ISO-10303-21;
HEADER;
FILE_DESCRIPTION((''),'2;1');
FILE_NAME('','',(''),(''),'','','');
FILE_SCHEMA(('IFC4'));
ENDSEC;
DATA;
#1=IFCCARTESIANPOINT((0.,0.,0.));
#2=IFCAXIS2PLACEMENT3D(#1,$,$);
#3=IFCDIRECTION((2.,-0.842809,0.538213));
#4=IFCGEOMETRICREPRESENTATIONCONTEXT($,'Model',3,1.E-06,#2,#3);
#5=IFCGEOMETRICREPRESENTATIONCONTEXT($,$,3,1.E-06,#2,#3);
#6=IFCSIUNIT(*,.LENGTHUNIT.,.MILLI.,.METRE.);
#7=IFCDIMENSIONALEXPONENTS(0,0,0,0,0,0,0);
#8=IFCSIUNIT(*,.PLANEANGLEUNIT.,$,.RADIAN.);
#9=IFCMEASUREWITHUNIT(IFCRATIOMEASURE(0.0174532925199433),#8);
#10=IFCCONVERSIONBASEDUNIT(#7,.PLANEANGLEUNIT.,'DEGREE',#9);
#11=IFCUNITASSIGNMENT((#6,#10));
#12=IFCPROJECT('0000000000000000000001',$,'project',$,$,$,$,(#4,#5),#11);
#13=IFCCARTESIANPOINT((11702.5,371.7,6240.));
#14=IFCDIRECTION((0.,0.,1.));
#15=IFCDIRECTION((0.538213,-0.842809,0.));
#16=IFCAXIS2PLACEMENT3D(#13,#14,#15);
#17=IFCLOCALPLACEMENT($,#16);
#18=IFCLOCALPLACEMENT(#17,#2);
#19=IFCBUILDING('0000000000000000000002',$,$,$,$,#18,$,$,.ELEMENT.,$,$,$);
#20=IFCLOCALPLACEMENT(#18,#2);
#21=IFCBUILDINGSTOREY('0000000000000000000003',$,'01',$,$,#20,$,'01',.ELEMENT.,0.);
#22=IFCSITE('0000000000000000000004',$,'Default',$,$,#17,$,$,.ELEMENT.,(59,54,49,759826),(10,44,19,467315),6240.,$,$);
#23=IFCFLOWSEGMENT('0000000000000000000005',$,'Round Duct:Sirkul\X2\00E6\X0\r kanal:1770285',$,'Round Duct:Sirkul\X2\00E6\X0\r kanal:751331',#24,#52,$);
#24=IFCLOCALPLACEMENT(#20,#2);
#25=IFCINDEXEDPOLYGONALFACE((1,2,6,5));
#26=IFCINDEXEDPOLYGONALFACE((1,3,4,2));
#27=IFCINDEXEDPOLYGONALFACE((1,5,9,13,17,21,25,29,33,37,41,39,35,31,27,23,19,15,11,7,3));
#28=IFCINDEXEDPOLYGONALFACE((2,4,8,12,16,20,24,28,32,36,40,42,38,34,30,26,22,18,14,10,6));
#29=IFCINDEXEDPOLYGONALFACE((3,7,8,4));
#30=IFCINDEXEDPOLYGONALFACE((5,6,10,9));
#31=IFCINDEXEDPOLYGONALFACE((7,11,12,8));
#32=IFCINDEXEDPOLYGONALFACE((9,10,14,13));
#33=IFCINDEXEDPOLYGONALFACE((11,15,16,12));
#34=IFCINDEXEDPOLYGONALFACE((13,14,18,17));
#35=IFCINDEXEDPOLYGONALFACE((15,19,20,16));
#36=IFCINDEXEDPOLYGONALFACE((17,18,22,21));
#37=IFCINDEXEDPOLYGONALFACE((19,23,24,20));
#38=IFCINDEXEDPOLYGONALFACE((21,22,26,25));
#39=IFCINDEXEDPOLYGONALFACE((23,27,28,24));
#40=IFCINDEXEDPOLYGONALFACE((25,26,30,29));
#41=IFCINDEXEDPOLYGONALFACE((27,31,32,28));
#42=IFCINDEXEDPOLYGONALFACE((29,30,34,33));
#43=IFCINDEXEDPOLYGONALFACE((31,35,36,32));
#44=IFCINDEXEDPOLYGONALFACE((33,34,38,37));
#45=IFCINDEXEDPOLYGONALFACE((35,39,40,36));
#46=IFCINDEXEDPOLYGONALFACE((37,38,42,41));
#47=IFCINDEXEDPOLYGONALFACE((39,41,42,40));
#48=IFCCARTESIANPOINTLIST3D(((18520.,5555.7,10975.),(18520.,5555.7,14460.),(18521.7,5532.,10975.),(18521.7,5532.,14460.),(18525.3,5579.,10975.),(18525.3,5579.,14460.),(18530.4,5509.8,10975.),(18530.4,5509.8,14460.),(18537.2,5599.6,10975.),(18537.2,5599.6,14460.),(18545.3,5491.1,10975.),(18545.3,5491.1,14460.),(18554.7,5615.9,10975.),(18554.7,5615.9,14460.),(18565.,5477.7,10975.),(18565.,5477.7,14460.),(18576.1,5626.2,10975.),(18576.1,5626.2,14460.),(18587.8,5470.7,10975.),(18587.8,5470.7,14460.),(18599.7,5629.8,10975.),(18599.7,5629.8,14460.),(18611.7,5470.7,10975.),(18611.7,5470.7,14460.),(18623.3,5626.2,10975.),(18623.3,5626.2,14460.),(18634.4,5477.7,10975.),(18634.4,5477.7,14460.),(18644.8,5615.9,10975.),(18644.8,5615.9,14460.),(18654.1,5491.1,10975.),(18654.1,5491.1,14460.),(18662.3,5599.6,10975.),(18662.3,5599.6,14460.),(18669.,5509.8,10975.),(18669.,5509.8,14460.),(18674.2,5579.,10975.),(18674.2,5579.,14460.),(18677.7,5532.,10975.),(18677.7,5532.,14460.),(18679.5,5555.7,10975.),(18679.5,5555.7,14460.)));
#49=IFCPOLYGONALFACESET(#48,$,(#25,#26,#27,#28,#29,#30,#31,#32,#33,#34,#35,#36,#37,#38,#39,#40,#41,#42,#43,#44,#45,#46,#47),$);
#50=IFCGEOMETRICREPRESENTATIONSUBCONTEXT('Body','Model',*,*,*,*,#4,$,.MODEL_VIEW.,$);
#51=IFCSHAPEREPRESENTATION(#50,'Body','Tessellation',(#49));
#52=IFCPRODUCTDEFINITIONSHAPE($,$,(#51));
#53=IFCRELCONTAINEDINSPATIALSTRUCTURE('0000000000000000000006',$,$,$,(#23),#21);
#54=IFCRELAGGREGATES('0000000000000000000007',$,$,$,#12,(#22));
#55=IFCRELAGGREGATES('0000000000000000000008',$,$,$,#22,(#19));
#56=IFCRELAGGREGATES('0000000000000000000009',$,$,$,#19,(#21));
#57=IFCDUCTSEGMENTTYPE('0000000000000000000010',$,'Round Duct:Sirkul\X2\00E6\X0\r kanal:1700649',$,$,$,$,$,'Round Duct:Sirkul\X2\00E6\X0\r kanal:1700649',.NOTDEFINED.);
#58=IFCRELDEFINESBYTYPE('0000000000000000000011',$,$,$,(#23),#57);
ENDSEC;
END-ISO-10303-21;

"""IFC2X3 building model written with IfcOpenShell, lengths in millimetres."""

from ifc_helpers import new_model, entity, si_unit, converted_unit, direction, frame, origin, origin_2d_with_axis, place, context, subcontext, project, spatial, circle, extrude, type_object, element, save


model = new_model("IFC2X3")

# Units and contexts
model_context = context("Model", 3, precision=1e-06, world=origin(), true_north=direction((2.0, -0.842809, 0.538213)))
context_of_model = context(None, 3, precision=1e-06, world=origin(), true_north=direction((2.0, -0.842809, 0.538213)))
body_context = subcontext(model_context, "Body", "Model", "MODEL_VIEW")
ifc_project = project(units=[si_unit("LENGTHUNIT", "METRE", prefix="MILLI"), converted_unit("PLANEANGLEUNIT", "DEGREE", entity("IfcRatioMeasure", 0.0174532925199433), si_unit("PLANEANGLEUNIT", "RADIAN"), dimensions=[0, 0, 0, 0, 0, 0, 0])], contexts=[model_context, context_of_model])

# Site, building, storey
site_placement = place(None, frame((11702.5, 371.7, 6240.0), z_axis=(0.0, 0.0, 1.0), x_axis=(0.538213, -0.842809, 0.0)))
site = spatial("IfcSite", under=ifc_project, at=site_placement, Name="Default", CompositionType="ELEMENT", RefLatitude=(59, 54, 49, 759826), RefLongitude=(10, 44, 19, 467315), RefElevation=6240.0)
building_placement = place(site_placement, origin())
building = spatial("IfcBuilding", under=site, at=building_placement, CompositionType="ELEMENT")
storey_placement = place(building_placement, origin())
storey = spatial("IfcBuildingStorey", under=building, at=storey_placement, Name="01", LongName="01", CompositionType="ELEMENT", Elevation=0.0)

# Flow segment
duct_segment_type_1 = type_object("IfcDuctSegmentType", Name="Round Duct:Sirkulær kanal:1700649", ElementType="Round Duct:Sirkulær kanal:1700649", PredefinedType="NOTDEFINED")
flow_segment_1_placement = place(storey_placement, origin())
element("IfcFlowSegment", 1, at=flow_segment_1_placement, inside=storey, type_object=duct_segment_type_1, Name="Round Duct:Sirkulær kanal:1770285", ObjectType="Round Duct:Sirkulær kanal:751331", context=body_context, shape_type="SweptSolid", body=[
    extrude(circle(Radius=80.0, at=origin_2d_with_axis()), frame((18599.7, 5549.8, 10975.0), z_axis=(0.0, 0.0, 1.0), x_axis=(0.0, 1.0, 0.0)), (0.0, 0.0, 1.0), 3485.0),
])

save(model, "model.ifc")
